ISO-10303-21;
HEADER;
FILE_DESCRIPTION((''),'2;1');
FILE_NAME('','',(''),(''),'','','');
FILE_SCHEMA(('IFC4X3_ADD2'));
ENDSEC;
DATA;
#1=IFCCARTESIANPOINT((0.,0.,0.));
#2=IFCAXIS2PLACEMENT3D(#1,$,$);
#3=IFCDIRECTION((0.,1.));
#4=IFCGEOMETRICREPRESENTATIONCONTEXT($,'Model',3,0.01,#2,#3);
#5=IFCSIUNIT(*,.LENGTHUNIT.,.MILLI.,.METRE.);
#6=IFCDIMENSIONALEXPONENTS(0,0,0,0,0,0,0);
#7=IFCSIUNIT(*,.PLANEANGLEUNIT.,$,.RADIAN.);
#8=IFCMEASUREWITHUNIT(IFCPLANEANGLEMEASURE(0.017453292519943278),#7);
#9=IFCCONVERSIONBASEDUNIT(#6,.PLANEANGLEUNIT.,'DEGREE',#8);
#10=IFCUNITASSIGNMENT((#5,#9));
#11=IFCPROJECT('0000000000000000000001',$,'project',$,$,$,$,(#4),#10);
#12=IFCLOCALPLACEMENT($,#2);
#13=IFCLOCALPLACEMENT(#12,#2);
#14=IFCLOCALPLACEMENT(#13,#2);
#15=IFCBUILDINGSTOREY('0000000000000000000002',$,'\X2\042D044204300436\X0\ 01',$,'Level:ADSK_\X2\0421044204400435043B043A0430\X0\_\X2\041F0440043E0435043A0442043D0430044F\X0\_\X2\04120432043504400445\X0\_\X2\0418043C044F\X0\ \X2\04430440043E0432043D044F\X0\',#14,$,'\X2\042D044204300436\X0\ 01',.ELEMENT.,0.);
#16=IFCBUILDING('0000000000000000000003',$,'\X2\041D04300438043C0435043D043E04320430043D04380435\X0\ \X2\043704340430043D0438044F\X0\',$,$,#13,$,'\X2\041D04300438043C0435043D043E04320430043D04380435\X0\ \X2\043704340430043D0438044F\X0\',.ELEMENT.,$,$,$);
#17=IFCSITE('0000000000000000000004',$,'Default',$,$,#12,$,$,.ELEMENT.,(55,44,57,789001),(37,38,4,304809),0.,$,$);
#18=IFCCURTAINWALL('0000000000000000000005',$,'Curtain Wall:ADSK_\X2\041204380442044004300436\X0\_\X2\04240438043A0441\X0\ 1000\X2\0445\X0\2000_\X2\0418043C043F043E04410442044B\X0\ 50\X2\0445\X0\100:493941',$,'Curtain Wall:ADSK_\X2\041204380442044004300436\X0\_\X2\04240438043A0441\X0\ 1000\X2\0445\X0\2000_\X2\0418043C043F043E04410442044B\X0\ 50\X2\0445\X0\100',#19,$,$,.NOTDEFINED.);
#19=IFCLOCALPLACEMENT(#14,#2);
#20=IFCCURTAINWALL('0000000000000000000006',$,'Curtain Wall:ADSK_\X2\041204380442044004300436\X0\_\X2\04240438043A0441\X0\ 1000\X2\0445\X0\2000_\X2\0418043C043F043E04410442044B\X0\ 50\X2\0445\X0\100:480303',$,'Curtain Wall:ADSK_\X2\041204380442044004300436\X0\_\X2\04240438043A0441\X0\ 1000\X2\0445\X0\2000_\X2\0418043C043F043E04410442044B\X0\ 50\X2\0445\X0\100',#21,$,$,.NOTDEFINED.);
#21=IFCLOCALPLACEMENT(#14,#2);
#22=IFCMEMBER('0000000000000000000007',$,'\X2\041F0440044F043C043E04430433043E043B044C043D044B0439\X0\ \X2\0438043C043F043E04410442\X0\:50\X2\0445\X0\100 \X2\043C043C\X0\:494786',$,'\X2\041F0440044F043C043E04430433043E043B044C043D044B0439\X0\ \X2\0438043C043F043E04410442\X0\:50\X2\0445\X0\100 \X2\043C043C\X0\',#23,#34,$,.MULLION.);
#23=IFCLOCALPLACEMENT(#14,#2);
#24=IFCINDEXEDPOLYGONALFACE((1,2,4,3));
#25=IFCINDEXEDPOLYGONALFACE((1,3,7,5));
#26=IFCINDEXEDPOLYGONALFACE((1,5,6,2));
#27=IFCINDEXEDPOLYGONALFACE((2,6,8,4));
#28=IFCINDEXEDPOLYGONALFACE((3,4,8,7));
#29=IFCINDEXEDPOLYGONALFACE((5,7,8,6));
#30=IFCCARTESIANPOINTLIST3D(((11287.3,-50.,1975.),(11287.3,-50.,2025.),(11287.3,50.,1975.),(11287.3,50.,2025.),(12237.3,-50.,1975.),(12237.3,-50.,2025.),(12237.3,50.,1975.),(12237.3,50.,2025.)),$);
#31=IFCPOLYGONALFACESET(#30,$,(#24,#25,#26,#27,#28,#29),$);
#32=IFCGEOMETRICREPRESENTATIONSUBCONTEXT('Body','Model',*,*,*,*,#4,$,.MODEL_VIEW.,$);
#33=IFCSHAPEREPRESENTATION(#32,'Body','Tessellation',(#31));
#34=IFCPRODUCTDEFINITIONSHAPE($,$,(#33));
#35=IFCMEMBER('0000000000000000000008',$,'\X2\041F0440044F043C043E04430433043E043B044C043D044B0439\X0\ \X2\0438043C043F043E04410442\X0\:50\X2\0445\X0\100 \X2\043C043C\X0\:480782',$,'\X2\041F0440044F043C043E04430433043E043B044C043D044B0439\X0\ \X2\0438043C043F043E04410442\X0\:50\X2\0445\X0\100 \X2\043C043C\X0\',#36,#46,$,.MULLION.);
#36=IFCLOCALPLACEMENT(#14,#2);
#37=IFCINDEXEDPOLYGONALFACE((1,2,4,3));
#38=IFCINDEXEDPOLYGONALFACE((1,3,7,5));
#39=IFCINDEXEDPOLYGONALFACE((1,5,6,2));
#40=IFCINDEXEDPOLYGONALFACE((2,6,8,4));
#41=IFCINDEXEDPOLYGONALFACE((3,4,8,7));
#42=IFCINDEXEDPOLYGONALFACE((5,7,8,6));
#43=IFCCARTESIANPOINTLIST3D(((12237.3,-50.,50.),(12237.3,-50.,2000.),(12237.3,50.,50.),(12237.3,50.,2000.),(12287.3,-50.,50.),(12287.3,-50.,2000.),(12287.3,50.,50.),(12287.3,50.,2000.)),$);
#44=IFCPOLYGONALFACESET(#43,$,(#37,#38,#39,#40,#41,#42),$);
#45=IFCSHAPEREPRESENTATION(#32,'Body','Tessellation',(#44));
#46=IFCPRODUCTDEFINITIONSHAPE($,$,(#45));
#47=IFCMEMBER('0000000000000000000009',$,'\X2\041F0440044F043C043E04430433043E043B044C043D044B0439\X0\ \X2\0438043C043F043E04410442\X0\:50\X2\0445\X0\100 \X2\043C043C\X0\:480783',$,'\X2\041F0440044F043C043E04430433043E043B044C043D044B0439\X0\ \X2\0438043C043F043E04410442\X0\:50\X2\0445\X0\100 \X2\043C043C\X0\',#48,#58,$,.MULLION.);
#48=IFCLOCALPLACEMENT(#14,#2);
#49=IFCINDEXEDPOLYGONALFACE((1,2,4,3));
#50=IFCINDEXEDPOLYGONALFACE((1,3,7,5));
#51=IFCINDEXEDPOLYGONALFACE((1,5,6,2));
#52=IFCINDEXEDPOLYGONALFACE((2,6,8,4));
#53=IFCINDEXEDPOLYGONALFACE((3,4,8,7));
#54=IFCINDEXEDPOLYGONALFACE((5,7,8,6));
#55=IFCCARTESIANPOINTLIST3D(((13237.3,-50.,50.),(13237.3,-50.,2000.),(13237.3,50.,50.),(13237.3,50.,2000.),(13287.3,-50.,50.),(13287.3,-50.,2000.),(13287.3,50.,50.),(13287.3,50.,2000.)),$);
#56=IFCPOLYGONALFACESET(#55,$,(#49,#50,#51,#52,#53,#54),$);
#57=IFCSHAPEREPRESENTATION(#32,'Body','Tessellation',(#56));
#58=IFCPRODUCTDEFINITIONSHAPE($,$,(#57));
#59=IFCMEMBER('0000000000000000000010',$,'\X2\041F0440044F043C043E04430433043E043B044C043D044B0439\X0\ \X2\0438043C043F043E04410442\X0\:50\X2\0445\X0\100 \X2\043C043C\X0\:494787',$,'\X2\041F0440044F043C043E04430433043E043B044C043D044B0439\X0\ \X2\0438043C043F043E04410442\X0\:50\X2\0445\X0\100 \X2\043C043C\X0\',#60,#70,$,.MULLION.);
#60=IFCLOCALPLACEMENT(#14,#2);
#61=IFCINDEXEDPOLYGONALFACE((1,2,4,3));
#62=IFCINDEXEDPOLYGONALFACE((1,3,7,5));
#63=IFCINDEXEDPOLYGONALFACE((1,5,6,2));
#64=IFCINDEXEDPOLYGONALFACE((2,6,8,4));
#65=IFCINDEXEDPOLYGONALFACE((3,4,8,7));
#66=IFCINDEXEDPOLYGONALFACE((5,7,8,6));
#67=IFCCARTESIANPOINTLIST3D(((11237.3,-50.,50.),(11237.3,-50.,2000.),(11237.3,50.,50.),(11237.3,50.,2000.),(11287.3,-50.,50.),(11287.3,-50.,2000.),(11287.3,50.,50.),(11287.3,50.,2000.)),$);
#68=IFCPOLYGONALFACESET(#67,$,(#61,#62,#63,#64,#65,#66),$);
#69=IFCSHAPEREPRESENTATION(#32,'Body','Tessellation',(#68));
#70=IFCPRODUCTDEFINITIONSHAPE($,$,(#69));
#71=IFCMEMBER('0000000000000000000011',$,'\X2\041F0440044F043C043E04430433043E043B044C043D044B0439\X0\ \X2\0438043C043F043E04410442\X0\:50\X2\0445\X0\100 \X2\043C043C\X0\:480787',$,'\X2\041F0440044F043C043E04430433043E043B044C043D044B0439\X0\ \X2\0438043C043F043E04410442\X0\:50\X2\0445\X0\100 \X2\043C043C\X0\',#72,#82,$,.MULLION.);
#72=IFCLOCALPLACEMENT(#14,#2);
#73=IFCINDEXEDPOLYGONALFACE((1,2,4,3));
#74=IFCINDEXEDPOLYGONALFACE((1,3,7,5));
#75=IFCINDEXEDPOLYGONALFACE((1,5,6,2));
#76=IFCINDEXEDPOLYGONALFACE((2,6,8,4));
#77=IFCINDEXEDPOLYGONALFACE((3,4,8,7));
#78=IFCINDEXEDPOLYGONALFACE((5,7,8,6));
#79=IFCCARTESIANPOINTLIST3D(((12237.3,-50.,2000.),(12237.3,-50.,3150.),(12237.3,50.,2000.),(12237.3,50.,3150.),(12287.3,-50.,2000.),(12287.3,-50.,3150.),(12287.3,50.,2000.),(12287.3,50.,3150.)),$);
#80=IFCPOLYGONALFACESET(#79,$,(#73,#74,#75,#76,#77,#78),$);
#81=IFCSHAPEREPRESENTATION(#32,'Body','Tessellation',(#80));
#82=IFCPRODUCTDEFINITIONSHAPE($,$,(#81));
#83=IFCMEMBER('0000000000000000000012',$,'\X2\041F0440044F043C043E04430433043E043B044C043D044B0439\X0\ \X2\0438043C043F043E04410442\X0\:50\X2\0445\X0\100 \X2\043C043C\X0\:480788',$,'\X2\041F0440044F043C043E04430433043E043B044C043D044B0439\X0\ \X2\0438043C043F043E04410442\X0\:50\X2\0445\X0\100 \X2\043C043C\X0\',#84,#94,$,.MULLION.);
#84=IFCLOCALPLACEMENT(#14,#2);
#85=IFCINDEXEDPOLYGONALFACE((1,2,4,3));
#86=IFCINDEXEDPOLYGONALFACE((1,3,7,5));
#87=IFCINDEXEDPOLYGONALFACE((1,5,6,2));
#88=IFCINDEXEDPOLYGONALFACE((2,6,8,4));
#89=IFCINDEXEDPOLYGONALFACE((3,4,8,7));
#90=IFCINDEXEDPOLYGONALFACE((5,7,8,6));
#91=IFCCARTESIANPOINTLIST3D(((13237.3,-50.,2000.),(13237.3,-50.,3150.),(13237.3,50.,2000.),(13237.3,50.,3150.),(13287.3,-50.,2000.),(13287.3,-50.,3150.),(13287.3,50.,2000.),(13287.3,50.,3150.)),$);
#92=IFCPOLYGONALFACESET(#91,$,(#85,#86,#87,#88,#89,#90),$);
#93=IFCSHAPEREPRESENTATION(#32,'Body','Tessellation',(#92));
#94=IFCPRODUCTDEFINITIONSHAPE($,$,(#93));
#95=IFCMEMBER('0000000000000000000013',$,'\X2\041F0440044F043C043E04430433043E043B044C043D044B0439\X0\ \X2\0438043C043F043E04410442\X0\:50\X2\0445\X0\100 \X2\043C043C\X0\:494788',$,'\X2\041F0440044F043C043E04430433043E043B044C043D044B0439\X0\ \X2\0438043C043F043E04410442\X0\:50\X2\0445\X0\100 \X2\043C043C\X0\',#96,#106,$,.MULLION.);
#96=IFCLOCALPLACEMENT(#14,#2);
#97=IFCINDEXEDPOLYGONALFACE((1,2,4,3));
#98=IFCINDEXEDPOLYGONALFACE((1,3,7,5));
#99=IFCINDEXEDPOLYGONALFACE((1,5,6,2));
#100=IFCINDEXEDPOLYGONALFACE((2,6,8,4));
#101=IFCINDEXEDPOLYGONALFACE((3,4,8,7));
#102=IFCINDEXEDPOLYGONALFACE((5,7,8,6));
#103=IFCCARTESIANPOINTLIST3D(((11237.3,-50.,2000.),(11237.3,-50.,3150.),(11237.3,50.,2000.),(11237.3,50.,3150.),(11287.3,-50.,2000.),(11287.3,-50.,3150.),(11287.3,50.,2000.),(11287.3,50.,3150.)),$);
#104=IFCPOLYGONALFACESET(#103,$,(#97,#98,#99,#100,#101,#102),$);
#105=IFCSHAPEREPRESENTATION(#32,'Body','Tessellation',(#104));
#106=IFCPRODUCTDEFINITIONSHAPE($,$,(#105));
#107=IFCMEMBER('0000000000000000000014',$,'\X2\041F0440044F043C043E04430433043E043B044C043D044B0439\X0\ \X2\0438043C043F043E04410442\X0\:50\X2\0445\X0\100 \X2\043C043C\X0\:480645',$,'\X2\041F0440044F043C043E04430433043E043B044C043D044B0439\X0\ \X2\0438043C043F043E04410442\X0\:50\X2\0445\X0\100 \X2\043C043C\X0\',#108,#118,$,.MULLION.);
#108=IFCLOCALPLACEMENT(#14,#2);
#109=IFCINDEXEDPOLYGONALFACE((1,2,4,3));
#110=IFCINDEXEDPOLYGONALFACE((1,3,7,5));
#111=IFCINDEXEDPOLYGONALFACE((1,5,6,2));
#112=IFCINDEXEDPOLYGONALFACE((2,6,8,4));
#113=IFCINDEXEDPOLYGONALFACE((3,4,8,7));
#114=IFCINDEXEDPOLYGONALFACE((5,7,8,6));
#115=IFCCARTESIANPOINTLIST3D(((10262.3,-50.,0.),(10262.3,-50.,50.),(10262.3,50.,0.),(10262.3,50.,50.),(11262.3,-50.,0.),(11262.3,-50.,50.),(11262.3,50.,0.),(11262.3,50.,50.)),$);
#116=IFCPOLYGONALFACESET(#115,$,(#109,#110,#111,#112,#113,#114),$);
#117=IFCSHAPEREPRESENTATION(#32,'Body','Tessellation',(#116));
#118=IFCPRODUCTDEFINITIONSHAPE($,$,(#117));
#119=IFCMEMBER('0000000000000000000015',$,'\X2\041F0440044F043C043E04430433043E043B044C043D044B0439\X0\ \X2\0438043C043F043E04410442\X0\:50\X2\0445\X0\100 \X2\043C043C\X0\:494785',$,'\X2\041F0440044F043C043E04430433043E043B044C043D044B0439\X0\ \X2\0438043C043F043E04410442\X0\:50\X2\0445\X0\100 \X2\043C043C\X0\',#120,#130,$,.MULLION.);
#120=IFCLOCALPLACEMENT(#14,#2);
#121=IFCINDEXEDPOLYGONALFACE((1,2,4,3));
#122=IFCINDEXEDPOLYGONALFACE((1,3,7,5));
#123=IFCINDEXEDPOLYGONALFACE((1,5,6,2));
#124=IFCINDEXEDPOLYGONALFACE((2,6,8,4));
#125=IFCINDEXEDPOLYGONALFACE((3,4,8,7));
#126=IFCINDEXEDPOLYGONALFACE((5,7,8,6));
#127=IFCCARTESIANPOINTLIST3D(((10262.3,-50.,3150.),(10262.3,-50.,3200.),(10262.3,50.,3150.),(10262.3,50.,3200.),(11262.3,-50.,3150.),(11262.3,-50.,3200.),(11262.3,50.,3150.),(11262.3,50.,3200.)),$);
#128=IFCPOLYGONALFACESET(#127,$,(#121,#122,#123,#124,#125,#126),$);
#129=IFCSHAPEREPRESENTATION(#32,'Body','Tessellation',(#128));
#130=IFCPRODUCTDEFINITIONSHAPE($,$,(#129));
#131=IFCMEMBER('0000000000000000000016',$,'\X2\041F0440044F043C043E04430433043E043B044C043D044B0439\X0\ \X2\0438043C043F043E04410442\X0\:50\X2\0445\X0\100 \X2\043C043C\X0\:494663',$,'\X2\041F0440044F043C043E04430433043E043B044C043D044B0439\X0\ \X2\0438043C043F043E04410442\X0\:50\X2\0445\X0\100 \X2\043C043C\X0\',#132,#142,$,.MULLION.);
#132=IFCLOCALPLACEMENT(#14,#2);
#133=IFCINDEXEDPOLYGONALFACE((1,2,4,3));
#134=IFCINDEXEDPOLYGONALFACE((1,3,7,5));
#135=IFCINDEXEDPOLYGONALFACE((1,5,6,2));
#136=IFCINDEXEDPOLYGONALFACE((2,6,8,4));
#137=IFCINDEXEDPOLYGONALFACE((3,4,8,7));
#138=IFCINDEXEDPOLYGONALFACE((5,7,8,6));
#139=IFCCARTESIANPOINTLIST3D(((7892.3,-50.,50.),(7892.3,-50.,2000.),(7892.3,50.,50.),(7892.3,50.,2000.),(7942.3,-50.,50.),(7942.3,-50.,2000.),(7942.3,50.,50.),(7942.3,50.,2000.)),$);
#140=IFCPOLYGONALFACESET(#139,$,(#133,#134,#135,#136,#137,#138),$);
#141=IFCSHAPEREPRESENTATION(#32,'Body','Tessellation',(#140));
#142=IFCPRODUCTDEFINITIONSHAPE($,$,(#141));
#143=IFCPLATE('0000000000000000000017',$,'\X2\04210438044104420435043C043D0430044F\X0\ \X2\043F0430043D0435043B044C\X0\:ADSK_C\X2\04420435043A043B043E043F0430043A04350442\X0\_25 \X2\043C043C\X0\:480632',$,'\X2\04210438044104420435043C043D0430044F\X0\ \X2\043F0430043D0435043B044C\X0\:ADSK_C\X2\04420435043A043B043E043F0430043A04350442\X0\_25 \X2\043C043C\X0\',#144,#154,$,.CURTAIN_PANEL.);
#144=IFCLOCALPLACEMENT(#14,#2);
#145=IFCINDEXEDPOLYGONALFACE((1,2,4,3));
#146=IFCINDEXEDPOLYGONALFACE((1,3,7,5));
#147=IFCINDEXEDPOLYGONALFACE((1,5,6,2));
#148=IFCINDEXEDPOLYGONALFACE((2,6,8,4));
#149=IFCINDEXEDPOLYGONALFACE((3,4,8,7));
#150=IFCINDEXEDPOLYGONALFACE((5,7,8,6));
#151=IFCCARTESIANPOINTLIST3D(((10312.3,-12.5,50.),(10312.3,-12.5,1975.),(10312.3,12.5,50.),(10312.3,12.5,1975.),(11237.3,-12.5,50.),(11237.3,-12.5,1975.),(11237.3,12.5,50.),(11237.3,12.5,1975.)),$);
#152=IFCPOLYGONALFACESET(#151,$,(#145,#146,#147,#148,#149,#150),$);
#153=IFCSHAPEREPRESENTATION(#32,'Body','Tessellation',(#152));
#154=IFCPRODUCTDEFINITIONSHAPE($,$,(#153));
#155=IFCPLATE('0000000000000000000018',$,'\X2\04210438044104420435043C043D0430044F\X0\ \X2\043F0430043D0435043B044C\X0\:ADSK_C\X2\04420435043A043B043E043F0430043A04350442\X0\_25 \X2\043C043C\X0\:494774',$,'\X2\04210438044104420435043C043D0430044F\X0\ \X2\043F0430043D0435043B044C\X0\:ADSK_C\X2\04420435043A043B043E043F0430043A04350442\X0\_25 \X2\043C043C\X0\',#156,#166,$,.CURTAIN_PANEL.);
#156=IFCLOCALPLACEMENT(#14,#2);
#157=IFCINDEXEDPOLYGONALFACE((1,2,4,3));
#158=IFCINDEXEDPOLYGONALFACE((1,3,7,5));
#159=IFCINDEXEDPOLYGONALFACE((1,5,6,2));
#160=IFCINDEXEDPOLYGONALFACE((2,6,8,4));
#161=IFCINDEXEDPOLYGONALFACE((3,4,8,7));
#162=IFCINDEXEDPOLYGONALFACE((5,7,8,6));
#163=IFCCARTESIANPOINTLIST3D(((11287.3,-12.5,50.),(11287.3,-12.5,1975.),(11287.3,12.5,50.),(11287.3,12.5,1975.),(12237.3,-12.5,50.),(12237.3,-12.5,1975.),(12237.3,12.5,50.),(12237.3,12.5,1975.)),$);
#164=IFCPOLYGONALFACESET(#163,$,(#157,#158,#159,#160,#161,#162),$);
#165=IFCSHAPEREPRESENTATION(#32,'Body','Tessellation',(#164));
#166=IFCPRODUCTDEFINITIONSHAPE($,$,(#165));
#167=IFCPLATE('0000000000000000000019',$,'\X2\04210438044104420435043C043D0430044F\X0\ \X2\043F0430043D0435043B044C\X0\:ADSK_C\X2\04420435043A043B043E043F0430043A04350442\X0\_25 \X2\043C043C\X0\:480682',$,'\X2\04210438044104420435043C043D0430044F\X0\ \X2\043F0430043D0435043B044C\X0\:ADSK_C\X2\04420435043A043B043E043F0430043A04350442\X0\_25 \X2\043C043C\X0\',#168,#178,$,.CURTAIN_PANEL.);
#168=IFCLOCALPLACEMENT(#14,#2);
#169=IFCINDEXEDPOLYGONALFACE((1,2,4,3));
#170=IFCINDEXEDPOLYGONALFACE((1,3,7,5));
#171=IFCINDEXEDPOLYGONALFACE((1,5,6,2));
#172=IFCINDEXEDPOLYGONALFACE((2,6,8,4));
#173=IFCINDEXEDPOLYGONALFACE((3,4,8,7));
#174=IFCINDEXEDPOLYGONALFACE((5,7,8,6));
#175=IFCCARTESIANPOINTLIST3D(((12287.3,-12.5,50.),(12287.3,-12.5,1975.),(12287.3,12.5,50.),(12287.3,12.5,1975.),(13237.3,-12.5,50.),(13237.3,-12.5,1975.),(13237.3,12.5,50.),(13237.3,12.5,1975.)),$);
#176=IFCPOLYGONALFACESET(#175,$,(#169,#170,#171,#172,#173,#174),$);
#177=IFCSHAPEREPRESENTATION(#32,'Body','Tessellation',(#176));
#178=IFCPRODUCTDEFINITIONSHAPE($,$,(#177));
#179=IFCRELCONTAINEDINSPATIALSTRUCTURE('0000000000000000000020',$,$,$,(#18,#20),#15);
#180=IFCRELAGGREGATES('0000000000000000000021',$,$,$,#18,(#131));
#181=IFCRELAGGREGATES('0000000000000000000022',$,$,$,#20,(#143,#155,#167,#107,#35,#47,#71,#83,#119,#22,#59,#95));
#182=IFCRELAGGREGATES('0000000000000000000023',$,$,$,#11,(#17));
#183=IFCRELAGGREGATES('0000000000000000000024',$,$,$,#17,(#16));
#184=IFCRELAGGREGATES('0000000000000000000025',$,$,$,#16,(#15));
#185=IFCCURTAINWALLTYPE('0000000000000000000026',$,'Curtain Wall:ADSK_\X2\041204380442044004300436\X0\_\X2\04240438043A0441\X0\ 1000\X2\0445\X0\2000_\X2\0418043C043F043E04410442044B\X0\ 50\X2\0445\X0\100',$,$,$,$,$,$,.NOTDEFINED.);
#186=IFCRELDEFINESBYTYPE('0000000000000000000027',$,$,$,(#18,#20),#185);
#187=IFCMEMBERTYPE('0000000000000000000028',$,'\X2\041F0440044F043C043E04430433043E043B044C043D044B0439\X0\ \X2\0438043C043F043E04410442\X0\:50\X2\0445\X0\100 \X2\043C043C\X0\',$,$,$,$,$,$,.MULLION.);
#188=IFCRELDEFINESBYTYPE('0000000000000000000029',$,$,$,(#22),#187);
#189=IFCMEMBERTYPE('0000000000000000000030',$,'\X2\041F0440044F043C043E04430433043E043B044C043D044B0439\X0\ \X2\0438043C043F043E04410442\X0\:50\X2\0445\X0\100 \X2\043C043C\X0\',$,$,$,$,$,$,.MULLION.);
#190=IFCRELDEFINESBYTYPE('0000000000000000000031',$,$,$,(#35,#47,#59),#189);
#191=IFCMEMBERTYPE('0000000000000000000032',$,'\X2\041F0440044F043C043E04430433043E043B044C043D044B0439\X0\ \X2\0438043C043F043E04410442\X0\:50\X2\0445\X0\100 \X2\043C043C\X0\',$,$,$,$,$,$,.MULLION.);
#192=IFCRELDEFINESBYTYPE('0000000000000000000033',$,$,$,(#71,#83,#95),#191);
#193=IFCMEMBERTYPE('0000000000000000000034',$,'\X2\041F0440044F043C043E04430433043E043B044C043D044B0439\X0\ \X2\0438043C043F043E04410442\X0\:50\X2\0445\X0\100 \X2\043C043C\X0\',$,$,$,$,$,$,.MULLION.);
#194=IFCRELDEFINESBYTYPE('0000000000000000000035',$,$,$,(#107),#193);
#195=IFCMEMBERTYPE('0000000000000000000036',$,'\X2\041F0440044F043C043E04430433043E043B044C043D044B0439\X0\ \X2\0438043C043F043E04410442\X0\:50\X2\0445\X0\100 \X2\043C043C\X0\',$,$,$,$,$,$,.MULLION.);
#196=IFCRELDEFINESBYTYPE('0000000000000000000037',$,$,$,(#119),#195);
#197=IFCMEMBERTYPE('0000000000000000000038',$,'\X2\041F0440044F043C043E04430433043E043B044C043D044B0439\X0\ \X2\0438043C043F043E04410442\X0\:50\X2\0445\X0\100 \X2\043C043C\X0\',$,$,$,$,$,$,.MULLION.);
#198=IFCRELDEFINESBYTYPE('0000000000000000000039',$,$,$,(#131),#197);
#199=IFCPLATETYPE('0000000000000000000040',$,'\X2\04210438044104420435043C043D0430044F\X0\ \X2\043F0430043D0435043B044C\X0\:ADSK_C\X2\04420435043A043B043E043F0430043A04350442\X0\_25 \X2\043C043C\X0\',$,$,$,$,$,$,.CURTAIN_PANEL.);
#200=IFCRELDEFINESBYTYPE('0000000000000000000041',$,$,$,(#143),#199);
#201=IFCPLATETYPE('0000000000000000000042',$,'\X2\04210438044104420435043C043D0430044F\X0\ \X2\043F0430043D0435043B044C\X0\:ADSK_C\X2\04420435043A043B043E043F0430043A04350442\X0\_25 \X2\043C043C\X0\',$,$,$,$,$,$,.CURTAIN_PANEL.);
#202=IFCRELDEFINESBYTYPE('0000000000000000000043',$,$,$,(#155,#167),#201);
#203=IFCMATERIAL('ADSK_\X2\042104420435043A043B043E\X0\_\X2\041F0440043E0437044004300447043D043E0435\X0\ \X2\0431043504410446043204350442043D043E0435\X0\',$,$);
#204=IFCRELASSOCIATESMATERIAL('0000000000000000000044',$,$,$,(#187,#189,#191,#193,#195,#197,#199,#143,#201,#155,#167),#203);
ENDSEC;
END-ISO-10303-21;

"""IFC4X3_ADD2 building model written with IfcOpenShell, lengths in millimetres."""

from ifc_helpers import new_model, entity, si_unit, converted_unit, direction, frame, frame_2d, origin, origin_2d_with_axis, place, context, subcontext, project, spatial, rectangle, extrude, source, transform, mapped, material, material_profile, profile_set, type_object, type_shapes, element, aggregate, save


model = new_model("IFC4X3_ADD2")

# Units and contexts
model_context = context("Model", 3, precision=0.01, world=origin(), true_north=direction((0.0, 1.0)))
body_context = subcontext(model_context, "Body", "Model", "MODEL_VIEW")
ifc_project = project(units=[si_unit("LENGTHUNIT", "METRE", prefix="MILLI"), converted_unit("PLANEANGLEUNIT", "DEGREE", entity("IfcPlaneAngleMeasure", 0.017453292519943278), si_unit("PLANEANGLEUNIT", "RADIAN"), dimensions=[0, 0, 0, 0, 0, 0, 0])], contexts=[model_context])

# Site, building, storey
site_placement = place(None, origin())
site = spatial("IfcSite", under=ifc_project, at=site_placement, Name="Default", CompositionType="ELEMENT", RefLatitude=(55, 44, 57, 789001), RefLongitude=(37, 38, 4, 304809), RefElevation=0.0)
building_placement = place(site_placement, origin())
building = spatial("IfcBuilding", under=site, at=building_placement, Name="Наименование здания", LongName="Наименование здания", CompositionType="ELEMENT")
storey_placement = place(building_placement, origin())
storey = spatial("IfcBuildingStorey", under=building, at=storey_placement, Name="Этаж 01", ObjectType="Level:ADSK_Стрелка_Проектная_Вверх_Имя уровня", LongName="Этаж 01", CompositionType="ELEMENT", Elevation=0.0)

# Curtain wall
curtain_wall_type = type_object("IfcCurtainWallType", Name="Curtain Wall:ADSK_Витраж_Фикс 1000х2000_Импосты 50х100", PredefinedType="NOTDEFINED")
curtain_wall_1_placement = place(storey_placement, origin())
curtain_wall_1 = element("IfcCurtainWall", 1, at=curtain_wall_1_placement, inside=storey, type_object=curtain_wall_type, Name="Curtain Wall:ADSK_Витраж_Фикс 1000х2000_Импосты 50х100:493941", ObjectType="Curtain Wall:ADSK_Витраж_Фикс 1000х2000_Импосты 50х100", PredefinedType="NOTDEFINED")
ifc_material_1 = material(Name="ADSK_Стекло_Прозрачное бесцветное")
ifc_material_profile = material_profile(ifc_material_1, rectangle(XDim=50.0, YDim=100.0, at=frame_2d((0.0, 0.0), x_axis=(1.0, 0.0))), Name="50х100 мм")
ifc_profile_set = profile_set([ifc_material_profile], Name="50х100 мм")

# Curtain wall, members
curtain_wall_2_placement = place(storey_placement, origin())
curtain_wall_2 = element("IfcCurtainWall", 2, at=curtain_wall_2_placement, inside=storey, type_object=curtain_wall_type, Name="Curtain Wall:ADSK_Витраж_Фикс 1000х2000_Импосты 50х100:480303", ObjectType="Curtain Wall:ADSK_Витраж_Фикс 1000х2000_Импосты 50х100", PredefinedType="NOTDEFINED")
member_type_1 = type_object("IfcMemberType", Name="Прямоугольный импост:50х100 мм", PredefinedType="MULLION", material=ifc_profile_set)
shared_shape_1 = source(origin(), body_context, "Body", "SweptSolid", [
    extrude(rectangle(XDim=50.0, YDim=100.0, at=frame_2d((0.0, 0.0), x_axis=(1.0, 0.0))), frame((0.0, 0.0, -950.0), z_axis=(0.0, 0.0, 1.0), x_axis=(-1.0, 0.0, 0.0)), (0.0, 0.0, 1.0), 950.0),
])
type_shapes(member_type_1, [shared_shape_1])
member_1_placement = place(curtain_wall_2_placement, frame((12237.3, 0.0, 2000.0), z_axis=(1.0, 0.0, 0.0), x_axis=(0.0, 0.0, 1.0)))
member_1 = element("IfcMember", 3, at=member_1_placement, type_object=member_type_1, Name="Прямоугольный импост:50х100 мм:494786", ObjectType="Прямоугольный импост:50х100 мм", PredefinedType="MULLION", context=body_context, shape_type="MappedRepresentation", body=[
    mapped(shared_shape_1, transform((0.0, 0.0, 0.0), scale=1.0)),
])
member_type_2 = type_object("IfcMemberType", Name="Прямоугольный импост:50х100 мм", PredefinedType="MULLION", material=ifc_profile_set)
shared_shape_2 = source(origin(), body_context, "Body", "SweptSolid", [
    extrude(rectangle(XDim=50.0, YDim=100.0, at=frame_2d((0.0, 0.0), x_axis=(1.0, 0.0))), frame((0.0, 0.0, -1950.0), z_axis=(0.0, 0.0, 1.0), x_axis=(-1.0, 0.0, 0.0)), (0.0, 0.0, 1.0), 1950.0),
])
type_shapes(member_type_2, [shared_shape_2])
member_2_placement = place(curtain_wall_2_placement, frame((12262.3, 0.0, 50.0), z_axis=(0.0, 0.0, -1.0), x_axis=(1.0, 0.0, 0.0)))
member_2 = element("IfcMember", 4, at=member_2_placement, type_object=member_type_2, Name="Прямоугольный импост:50х100 мм:480782", ObjectType="Прямоугольный импост:50х100 мм", PredefinedType="MULLION", context=body_context, shape_type="MappedRepresentation", body=[
    mapped(shared_shape_2, transform((0.0, 0.0, 0.0), scale=1.0)),
])
member_3_placement = place(curtain_wall_2_placement, frame((13262.3, 0.0, 50.0), z_axis=(0.0, 0.0, -1.0), x_axis=(1.0, 0.0, 0.0)))
member_3 = element("IfcMember", 5, at=member_3_placement, type_object=member_type_2, Name="Прямоугольный импост:50х100 мм:480783", ObjectType="Прямоугольный импост:50х100 мм", PredefinedType="MULLION", context=body_context, shape_type="MappedRepresentation", body=[
    mapped(shared_shape_2, transform((0.0, 0.0, 0.0), scale=1.0)),
])
member_4_placement = place(curtain_wall_2_placement, frame((11262.3, 0.0, 50.0), z_axis=(0.0, 0.0, -1.0), x_axis=(1.0, 0.0, 0.0)))
member_4 = element("IfcMember", 6, at=member_4_placement, type_object=member_type_2, Name="Прямоугольный импост:50х100 мм:494787", ObjectType="Прямоугольный импост:50х100 мм", PredefinedType="MULLION", context=body_context, shape_type="MappedRepresentation", body=[
    mapped(shared_shape_2, transform((0.0, 0.0, 0.0), scale=1.0)),
])
member_type_3 = type_object("IfcMemberType", Name="Прямоугольный импост:50х100 мм", PredefinedType="MULLION", material=ifc_profile_set)
shared_shape_3 = source(origin(), body_context, "Body", "SweptSolid", [
    extrude(rectangle(XDim=50.0, YDim=100.0, at=frame_2d((0.0, 0.0), x_axis=(1.0, 0.0))), frame((0.0, 0.0, -1150.0), z_axis=(0.0, 0.0, 1.0), x_axis=(-1.0, 0.0, 0.0)), (0.0, 0.0, 1.0), 1150.0),
])
type_shapes(member_type_3, [shared_shape_3])
member_5_placement = place(curtain_wall_2_placement, frame((12262.3, 0.0, 2000.0), z_axis=(0.0, 0.0, -1.0), x_axis=(1.0, 0.0, 0.0)))
member_5 = element("IfcMember", 7, at=member_5_placement, type_object=member_type_3, Name="Прямоугольный импост:50х100 мм:480787", ObjectType="Прямоугольный импост:50х100 мм", PredefinedType="MULLION", context=body_context, shape_type="MappedRepresentation", body=[
    mapped(shared_shape_3, transform((0.0, 0.0, 0.0), scale=1.0)),
])
member_6_placement = place(curtain_wall_2_placement, frame((13262.3, 0.0, 2000.0), z_axis=(0.0, 0.0, -1.0), x_axis=(1.0, 0.0, 0.0)))
member_6 = element("IfcMember", 8, at=member_6_placement, type_object=member_type_3, Name="Прямоугольный импост:50х100 мм:480788", ObjectType="Прямоугольный импост:50х100 мм", PredefinedType="MULLION", context=body_context, shape_type="MappedRepresentation", body=[
    mapped(shared_shape_3, transform((0.0, 0.0, 0.0), scale=1.0)),
])
member_7_placement = place(curtain_wall_2_placement, frame((11262.3, 0.0, 2000.0), z_axis=(0.0, 0.0, -1.0), x_axis=(1.0, 0.0, 0.0)))
member_7 = element("IfcMember", 9, at=member_7_placement, type_object=member_type_3, Name="Прямоугольный импост:50х100 мм:494788", ObjectType="Прямоугольный импост:50х100 мм", PredefinedType="MULLION", context=body_context, shape_type="MappedRepresentation", body=[
    mapped(shared_shape_3, transform((0.0, 0.0, 0.0), scale=1.0)),
])
member_type_4 = type_object("IfcMemberType", Name="Прямоугольный импост:50х100 мм", PredefinedType="MULLION", material=ifc_profile_set)
shared_shape_4 = source(origin(), body_context, "Body", "SweptSolid", [
    extrude(rectangle(XDim=50.0, YDim=100.0, at=frame_2d((0.0, 0.0), x_axis=(1.0, 0.0))), frame((-25.0, 0.0, -1000.0), z_axis=(0.0, 0.0, 1.0), x_axis=(-1.0, 0.0, 0.0)), (0.0, 0.0, 1.0), 1000.0),
])
type_shapes(member_type_4, [shared_shape_4])
member_8_placement = place(curtain_wall_2_placement, frame((10262.3, 0.0, 0.0), z_axis=(-1.0, 0.0, 0.0), x_axis=(0.0, 0.0, -1.0)))
member_8 = element("IfcMember", 10, at=member_8_placement, type_object=member_type_4, Name="Прямоугольный импост:50х100 мм:480645", ObjectType="Прямоугольный импост:50х100 мм", PredefinedType="MULLION", context=body_context, shape_type="MappedRepresentation", body=[
    mapped(shared_shape_4, transform((0.0, 0.0, 0.0), scale=1.0)),
])
member_type_5 = type_object("IfcMemberType", Name="Прямоугольный импост:50х100 мм", PredefinedType="MULLION", material=ifc_profile_set)
shared_shape_5 = source(origin(), body_context, "Body", "SweptSolid", [
    extrude(rectangle(XDim=50.0, YDim=100.0, at=frame_2d((0.0, 0.0), x_axis=(1.0, 0.0))), frame((-25.0, 0.0, -1000.0), z_axis=(0.0, 0.0, 1.0), x_axis=(-1.0, 0.0, 0.0)), (0.0, 0.0, 1.0), 1000.0),
])
type_shapes(member_type_5, [shared_shape_5])
member_9_placement = place(curtain_wall_2_placement, frame((11262.3, 0.0, 3200.0), z_axis=(1.0, 0.0, 0.0), x_axis=(0.0, 0.0, 1.0)))
member_9 = element("IfcMember", 11, at=member_9_placement, type_object=member_type_5, Name="Прямоугольный импост:50х100 мм:494785", ObjectType="Прямоугольный импост:50х100 мм", PredefinedType="MULLION", context=body_context, shape_type="MappedRepresentation", body=[
    mapped(shared_shape_5, transform((0.0, 0.0, 0.0), scale=1.0)),
])

# Member
member_type_6 = type_object("IfcMemberType", Name="Прямоугольный импост:50х100 мм", PredefinedType="MULLION", material=ifc_profile_set)
shared_shape_6 = source(origin(), body_context, "Body", "SweptSolid", [
    extrude(rectangle(XDim=50.0, YDim=100.0, at=frame_2d((0.0, 0.0), x_axis=(1.0, 0.0))), frame((-25.0, 0.0, -1950.0), z_axis=(0.0, 0.0, 1.0), x_axis=(-1.0, 0.0, 0.0)), (0.0, 0.0, 1.0), 1950.0),
])
type_shapes(member_type_6, [shared_shape_6])
member_10_placement = place(curtain_wall_1_placement, frame((7942.3, 0.0, 50.0), z_axis=(0.0, 0.0, -1.0), x_axis=(1.0, 0.0, 0.0)))
member_10 = element("IfcMember", 12, at=member_10_placement, type_object=member_type_6, Name="Прямоугольный импост:50х100 мм:494663", ObjectType="Прямоугольный импост:50х100 мм", PredefinedType="MULLION", context=body_context, shape_type="MappedRepresentation", body=[
    mapped(shared_shape_6, transform((0.0, 0.0, 0.0), scale=1.0)),
])
aggregate(curtain_wall_1, [member_10])

# Plates
plate_type_1 = type_object("IfcPlateType", Name="Системная панель:ADSK_Cтеклопакет_25 мм", PredefinedType="CURTAIN_PANEL", material=ifc_material_1)
shared_shape_7 = source(origin(), body_context, "Body", "SweptSolid", [
    extrude(rectangle(XDim=25.0, YDim=925.0, at=origin_2d_with_axis()), frame((0.0, 0.0, 0.0), z_axis=(0.0, 0.0, 1.0), x_axis=(0.0, 1.0, 0.0)), (0.0, 0.0, 1.0), 1925.0),
])
type_shapes(plate_type_1, [shared_shape_7])
plate_1_placement = place(curtain_wall_2_placement, frame((10774.8, 0.0, 50.0)))
plate_1 = element("IfcPlate", 13, at=plate_1_placement, type_object=plate_type_1, material=ifc_material_1, Name="Системная панель:ADSK_Cтеклопакет_25 мм:480632", ObjectType="Системная панель:ADSK_Cтеклопакет_25 мм", PredefinedType="CURTAIN_PANEL", context=body_context, shape_type="MappedRepresentation", body=[
    mapped(shared_shape_7, transform((0.0, 0.0, 0.0), scale=1.0)),
])
plate_type_2 = type_object("IfcPlateType", Name="Системная панель:ADSK_Cтеклопакет_25 мм", PredefinedType="CURTAIN_PANEL", material=ifc_material_1)
shared_shape_8 = source(origin(), body_context, "Body", "SweptSolid", [
    extrude(rectangle(XDim=25.0, YDim=950.0, at=origin_2d_with_axis()), frame((0.0, 0.0, 0.0), z_axis=(0.0, 0.0, 1.0), x_axis=(0.0, 1.0, 0.0)), (0.0, 0.0, 1.0), 1925.0),
])
type_shapes(plate_type_2, [shared_shape_8])
plate_2_placement = place(curtain_wall_2_placement, frame((11762.3, 0.0, 50.0)))
plate_2 = element("IfcPlate", 14, at=plate_2_placement, type_object=plate_type_2, material=ifc_material_1, Name="Системная панель:ADSK_Cтеклопакет_25 мм:494774", ObjectType="Системная панель:ADSK_Cтеклопакет_25 мм", PredefinedType="CURTAIN_PANEL", context=body_context, shape_type="MappedRepresentation", body=[
    mapped(shared_shape_8, transform((0.0, 0.0, 0.0), scale=1.0)),
])
plate_3_placement = place(curtain_wall_2_placement, frame((12762.3, 0.0, 50.0)))
plate_3 = element("IfcPlate", 15, at=plate_3_placement, type_object=plate_type_2, material=ifc_material_1, Name="Системная панель:ADSK_Cтеклопакет_25 мм:480682", ObjectType="Системная панель:ADSK_Cтеклопакет_25 мм", PredefinedType="CURTAIN_PANEL", context=body_context, shape_type="MappedRepresentation", body=[
    mapped(shared_shape_8, transform((0.0, 0.0, 0.0), scale=1.0)),
])
aggregate(curtain_wall_2, [plate_1, plate_2, plate_3, member_8, member_2, member_3, member_5, member_6, member_9, member_1, member_4, member_7])

save(model, "model.ifc")
